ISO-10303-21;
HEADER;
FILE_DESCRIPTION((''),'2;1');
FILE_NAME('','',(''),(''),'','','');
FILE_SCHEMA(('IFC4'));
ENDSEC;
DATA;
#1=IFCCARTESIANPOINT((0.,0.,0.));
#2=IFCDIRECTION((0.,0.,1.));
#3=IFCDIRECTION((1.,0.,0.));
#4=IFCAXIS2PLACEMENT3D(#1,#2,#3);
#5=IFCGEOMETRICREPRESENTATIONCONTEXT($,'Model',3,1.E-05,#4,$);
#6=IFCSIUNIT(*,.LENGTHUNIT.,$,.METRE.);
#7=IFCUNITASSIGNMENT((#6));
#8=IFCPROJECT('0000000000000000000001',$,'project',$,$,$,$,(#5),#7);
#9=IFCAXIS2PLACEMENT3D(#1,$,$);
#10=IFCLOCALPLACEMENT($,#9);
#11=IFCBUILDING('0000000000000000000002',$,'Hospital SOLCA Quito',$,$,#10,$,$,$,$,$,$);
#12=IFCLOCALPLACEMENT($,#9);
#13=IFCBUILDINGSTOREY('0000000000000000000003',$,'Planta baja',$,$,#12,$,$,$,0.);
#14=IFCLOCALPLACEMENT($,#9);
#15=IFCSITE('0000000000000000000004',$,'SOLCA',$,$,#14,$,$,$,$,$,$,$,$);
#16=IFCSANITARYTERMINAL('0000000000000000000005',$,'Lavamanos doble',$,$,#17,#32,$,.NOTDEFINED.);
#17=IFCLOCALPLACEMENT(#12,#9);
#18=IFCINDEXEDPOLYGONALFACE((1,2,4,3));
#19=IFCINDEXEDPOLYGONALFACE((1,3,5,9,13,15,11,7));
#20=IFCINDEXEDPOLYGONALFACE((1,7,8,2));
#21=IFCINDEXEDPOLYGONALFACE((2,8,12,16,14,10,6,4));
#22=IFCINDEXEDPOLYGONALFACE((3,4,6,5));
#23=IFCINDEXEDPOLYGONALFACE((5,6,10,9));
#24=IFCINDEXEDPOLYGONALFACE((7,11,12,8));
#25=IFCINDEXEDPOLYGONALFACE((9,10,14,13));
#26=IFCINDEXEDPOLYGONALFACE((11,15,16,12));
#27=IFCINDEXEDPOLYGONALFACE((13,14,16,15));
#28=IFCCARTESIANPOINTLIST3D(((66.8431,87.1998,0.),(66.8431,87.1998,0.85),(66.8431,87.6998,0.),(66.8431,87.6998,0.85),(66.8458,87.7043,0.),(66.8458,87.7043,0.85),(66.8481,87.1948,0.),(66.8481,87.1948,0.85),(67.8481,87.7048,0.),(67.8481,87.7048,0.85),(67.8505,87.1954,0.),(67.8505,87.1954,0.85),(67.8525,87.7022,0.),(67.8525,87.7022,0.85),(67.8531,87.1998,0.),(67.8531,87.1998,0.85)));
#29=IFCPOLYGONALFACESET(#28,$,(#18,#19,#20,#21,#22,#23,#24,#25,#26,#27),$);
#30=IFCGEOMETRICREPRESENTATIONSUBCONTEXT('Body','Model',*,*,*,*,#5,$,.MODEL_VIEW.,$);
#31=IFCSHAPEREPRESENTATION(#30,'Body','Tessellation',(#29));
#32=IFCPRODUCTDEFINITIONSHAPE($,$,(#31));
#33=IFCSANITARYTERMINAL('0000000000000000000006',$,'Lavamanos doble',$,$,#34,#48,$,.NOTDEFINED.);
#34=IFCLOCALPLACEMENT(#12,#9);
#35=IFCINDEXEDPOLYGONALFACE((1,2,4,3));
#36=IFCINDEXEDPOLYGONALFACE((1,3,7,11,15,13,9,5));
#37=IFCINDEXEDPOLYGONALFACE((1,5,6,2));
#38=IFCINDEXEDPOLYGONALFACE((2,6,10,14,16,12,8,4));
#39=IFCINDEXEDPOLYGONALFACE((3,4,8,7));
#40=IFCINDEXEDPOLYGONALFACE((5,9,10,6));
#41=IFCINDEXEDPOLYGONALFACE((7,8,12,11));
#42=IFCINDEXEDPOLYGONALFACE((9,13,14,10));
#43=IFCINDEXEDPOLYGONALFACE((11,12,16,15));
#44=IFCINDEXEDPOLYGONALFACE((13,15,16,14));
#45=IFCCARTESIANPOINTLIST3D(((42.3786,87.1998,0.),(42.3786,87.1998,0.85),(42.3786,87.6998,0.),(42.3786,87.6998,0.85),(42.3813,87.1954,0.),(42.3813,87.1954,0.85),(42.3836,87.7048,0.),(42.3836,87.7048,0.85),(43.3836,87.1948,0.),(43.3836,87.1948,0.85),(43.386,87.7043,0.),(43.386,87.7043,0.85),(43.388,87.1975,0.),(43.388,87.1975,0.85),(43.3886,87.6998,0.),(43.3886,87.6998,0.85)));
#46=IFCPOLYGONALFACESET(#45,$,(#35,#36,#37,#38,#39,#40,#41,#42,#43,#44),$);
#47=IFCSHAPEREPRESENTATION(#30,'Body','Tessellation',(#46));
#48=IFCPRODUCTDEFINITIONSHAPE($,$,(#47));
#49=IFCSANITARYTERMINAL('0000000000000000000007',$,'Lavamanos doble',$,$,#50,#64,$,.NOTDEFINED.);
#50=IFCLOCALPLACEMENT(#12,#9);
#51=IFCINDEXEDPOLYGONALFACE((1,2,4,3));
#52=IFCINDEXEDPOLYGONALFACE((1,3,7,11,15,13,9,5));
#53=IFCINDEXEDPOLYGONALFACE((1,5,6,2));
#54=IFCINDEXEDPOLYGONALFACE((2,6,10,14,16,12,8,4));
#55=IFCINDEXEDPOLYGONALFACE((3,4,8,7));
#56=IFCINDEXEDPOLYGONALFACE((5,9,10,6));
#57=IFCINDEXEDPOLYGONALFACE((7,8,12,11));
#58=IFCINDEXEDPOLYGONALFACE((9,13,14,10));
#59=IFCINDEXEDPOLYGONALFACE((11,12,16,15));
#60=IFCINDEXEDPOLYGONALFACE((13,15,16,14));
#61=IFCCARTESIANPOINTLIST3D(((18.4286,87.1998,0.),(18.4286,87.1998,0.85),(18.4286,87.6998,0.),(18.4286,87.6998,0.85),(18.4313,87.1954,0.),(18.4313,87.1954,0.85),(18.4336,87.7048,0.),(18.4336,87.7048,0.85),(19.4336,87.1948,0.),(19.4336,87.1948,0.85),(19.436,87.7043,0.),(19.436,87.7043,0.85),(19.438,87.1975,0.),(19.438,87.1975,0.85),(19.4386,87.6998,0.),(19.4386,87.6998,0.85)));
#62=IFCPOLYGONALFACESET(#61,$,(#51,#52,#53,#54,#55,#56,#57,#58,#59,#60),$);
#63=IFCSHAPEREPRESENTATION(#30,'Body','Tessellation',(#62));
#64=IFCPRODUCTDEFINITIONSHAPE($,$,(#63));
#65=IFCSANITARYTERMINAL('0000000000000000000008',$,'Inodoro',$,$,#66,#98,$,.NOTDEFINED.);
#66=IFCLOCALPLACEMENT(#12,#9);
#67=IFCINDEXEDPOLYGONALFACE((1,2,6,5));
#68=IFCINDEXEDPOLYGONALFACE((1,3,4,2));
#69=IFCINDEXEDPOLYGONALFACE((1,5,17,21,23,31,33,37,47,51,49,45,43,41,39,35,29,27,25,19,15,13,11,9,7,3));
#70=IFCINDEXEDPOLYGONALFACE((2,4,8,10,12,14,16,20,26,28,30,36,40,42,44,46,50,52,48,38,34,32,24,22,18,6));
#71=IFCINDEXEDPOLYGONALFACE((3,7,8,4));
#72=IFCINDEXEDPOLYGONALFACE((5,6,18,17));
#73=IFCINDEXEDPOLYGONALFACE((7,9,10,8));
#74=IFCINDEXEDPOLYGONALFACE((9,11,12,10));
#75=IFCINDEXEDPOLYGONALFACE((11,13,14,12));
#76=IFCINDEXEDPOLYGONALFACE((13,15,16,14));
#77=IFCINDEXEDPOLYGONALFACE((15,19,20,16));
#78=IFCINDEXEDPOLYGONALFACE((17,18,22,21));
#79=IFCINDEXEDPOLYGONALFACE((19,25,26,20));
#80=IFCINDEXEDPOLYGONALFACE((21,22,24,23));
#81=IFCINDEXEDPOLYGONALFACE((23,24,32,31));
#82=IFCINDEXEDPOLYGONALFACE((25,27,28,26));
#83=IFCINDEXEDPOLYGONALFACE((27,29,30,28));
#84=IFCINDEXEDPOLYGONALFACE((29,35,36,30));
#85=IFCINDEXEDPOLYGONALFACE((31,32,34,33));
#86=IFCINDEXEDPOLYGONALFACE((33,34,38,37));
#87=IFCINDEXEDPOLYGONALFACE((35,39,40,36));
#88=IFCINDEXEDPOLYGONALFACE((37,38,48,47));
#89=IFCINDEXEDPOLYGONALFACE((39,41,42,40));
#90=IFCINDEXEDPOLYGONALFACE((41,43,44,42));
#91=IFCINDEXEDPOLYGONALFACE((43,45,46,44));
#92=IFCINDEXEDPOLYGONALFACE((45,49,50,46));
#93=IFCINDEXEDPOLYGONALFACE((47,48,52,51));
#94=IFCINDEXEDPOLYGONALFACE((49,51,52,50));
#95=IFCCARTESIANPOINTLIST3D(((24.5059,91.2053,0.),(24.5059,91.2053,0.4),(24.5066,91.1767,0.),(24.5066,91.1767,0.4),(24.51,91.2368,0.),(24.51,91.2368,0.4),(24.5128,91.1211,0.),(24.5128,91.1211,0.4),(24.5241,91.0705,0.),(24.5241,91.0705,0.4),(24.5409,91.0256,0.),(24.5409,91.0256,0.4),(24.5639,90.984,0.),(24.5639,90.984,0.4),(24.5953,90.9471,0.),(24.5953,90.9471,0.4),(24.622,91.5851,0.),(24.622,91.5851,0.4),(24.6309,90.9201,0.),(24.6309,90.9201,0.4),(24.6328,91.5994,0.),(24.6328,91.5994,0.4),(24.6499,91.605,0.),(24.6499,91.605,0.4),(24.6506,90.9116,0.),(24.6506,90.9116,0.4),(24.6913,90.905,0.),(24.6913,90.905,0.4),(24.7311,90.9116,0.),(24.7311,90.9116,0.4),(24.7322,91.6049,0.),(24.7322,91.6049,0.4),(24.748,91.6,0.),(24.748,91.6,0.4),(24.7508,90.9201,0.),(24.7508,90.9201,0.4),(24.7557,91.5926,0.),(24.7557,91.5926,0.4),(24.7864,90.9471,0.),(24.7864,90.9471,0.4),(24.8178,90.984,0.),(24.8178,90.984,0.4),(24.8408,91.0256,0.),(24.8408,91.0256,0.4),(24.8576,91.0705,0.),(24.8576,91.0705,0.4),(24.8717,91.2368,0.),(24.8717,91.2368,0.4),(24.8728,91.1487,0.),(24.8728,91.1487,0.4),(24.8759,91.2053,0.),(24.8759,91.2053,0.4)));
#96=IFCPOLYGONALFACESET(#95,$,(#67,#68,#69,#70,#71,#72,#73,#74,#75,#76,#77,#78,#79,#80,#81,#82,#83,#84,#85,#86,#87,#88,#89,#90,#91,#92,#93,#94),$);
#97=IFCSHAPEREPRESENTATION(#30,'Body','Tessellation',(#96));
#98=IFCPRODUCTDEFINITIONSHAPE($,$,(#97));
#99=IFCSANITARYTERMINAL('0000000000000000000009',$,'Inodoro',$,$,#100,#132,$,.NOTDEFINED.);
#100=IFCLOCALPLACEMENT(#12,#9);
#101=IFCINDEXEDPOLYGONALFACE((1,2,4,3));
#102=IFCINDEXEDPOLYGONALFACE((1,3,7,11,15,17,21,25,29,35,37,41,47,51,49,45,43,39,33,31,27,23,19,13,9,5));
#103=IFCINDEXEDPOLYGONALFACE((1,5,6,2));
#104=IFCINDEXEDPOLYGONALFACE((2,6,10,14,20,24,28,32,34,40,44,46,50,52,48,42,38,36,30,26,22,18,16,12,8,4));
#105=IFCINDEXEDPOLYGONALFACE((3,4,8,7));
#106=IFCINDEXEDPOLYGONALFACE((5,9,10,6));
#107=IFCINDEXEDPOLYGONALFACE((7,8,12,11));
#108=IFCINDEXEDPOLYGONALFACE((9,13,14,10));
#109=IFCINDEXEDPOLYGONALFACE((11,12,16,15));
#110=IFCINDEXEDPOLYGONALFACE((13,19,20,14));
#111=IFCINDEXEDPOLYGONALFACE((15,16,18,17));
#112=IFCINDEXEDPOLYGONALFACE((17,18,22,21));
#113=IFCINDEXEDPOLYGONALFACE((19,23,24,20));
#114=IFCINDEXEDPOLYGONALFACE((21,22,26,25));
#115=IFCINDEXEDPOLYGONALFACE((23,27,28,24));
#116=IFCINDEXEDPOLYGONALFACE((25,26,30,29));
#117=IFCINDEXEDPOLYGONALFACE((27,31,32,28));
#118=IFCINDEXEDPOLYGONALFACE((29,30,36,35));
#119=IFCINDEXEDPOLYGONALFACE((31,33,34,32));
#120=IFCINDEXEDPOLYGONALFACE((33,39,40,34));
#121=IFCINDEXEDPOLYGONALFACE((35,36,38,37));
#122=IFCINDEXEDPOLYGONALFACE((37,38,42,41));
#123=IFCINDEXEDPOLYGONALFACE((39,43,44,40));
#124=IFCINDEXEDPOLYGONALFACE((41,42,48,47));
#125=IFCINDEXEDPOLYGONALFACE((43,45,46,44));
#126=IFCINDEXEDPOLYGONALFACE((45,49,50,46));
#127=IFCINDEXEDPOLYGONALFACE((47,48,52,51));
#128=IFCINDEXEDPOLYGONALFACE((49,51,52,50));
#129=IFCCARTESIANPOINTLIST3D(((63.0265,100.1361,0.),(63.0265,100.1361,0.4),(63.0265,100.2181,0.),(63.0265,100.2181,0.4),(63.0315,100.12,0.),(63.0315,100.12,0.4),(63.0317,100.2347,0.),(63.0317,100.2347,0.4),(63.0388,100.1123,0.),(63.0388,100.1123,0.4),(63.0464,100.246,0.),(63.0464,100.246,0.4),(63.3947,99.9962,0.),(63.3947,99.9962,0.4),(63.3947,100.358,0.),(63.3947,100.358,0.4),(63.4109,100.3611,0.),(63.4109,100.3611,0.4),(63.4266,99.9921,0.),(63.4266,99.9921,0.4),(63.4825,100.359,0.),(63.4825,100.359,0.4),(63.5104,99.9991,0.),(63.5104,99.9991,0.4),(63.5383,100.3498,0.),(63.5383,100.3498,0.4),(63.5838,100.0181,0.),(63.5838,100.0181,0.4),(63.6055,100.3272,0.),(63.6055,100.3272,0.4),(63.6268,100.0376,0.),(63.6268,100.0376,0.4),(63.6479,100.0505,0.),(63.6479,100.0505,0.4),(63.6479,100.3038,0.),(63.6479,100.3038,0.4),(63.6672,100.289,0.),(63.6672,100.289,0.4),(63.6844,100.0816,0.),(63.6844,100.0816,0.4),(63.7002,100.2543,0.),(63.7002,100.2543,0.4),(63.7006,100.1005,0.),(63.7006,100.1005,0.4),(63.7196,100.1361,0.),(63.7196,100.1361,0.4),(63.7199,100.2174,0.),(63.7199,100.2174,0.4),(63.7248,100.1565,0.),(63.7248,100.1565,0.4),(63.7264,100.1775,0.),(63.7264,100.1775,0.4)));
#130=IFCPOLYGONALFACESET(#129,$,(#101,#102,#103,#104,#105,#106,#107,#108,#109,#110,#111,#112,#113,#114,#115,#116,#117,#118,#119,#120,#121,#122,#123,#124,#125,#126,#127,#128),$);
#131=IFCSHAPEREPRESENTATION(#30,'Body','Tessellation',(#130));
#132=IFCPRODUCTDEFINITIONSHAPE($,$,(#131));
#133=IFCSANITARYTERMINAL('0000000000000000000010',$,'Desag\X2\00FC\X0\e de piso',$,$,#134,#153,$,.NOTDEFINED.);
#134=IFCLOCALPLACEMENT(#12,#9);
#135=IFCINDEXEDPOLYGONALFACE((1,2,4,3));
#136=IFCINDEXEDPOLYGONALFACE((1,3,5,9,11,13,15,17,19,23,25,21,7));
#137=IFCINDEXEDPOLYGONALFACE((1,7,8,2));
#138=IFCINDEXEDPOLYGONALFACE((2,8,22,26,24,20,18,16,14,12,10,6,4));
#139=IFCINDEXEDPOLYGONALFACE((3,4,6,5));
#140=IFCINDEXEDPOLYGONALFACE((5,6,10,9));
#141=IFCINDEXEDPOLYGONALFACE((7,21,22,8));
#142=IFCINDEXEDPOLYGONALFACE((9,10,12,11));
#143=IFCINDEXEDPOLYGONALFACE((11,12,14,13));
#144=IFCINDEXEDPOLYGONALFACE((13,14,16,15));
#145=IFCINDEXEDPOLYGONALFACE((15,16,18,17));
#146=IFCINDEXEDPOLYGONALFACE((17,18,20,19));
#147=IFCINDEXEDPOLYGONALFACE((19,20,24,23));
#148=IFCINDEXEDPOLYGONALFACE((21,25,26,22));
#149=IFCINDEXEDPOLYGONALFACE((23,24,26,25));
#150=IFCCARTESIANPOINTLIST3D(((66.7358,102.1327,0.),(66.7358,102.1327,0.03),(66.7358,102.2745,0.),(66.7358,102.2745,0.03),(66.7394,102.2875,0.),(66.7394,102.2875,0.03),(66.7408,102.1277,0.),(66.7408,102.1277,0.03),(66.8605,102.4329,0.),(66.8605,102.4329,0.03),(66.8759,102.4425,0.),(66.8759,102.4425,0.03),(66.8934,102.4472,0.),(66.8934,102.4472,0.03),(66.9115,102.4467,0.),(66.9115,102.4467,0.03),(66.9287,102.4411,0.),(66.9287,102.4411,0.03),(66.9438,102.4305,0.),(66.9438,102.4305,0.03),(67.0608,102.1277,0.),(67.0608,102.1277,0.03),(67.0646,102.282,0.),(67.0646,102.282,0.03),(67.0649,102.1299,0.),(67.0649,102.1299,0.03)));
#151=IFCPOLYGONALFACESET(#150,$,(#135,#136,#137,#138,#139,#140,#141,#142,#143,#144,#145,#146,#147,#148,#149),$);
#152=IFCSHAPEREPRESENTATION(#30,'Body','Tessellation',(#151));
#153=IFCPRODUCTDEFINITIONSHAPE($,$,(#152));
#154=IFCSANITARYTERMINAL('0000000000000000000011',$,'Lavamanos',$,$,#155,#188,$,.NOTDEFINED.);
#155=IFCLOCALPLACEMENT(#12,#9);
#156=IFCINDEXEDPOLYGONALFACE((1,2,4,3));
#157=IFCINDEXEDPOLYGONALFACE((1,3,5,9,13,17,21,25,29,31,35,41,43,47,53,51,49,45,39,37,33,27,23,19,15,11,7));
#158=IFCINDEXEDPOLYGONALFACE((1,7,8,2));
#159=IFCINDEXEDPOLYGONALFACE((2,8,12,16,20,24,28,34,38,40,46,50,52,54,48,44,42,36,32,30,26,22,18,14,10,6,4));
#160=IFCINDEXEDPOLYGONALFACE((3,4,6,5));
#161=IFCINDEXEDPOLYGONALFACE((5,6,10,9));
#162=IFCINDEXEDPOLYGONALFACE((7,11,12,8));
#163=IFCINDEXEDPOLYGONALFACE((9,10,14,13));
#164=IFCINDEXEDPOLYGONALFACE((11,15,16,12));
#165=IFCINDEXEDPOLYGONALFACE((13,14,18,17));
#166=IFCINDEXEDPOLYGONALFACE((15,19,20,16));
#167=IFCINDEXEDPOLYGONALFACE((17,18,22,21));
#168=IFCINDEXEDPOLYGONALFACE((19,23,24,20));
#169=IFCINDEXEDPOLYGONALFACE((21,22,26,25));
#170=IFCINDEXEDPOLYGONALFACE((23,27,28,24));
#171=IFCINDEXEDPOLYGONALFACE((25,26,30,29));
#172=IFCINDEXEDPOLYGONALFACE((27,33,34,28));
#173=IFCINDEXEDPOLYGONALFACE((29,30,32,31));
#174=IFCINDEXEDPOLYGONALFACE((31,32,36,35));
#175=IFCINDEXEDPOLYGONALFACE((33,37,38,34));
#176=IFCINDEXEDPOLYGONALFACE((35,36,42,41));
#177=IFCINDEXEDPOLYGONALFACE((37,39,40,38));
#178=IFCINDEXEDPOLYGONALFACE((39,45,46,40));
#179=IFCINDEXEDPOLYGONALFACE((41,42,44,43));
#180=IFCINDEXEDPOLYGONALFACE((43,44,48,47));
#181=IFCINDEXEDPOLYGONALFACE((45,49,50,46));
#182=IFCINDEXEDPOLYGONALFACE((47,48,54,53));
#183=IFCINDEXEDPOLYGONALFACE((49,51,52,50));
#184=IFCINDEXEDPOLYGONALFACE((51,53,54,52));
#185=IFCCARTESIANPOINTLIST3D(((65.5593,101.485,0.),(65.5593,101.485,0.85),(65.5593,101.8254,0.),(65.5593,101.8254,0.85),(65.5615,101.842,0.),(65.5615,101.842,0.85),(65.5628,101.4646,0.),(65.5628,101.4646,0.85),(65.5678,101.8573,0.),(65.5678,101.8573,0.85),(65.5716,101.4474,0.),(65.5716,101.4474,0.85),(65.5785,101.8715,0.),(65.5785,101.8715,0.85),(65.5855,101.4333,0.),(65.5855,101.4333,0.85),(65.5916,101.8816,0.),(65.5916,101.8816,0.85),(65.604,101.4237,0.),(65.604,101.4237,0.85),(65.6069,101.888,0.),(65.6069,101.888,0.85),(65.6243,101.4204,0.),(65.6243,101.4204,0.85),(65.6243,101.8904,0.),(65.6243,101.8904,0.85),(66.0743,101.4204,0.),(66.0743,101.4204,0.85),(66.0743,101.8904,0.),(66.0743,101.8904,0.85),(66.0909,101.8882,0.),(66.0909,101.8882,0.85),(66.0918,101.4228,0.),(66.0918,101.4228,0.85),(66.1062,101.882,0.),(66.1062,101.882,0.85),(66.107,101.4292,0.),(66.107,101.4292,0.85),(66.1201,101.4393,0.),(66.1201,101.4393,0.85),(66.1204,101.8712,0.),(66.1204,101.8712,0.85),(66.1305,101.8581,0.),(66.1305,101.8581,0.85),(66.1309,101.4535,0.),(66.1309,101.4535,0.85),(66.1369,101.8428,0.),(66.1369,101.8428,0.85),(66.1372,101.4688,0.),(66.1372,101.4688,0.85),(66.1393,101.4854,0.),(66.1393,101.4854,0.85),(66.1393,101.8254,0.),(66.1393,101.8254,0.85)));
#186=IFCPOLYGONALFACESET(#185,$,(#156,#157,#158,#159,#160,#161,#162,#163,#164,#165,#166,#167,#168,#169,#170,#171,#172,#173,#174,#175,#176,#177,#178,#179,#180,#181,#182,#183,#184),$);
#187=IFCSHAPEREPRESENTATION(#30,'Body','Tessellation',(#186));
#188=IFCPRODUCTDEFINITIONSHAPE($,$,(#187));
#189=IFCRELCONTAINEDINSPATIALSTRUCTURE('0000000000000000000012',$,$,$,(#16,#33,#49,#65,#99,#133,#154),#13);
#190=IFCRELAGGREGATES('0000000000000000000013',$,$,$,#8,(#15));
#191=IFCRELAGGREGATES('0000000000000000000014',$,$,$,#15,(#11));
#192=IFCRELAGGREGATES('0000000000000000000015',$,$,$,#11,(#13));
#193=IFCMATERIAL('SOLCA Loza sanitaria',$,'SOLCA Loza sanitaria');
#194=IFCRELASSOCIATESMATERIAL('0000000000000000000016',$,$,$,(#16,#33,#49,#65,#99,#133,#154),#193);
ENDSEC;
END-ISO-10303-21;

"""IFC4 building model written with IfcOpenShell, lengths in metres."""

from ifc_helpers import new_model, si_unit, origin, origin_with_axes, place, context, subcontext, project, spatial, polyline, outline, extrude, material, element, save


model = new_model("IFC4")

# Units and contexts
model_context = context("Model", 3, precision=1e-05, world=origin_with_axes())
body_context = subcontext(model_context, "Body", "Model", "MODEL_VIEW")
ifc_project = project(units=[si_unit("LENGTHUNIT", "METRE")], contexts=[model_context])

# Site, building, storey
site_placement = place(None, origin())
site = spatial("IfcSite", under=ifc_project, at=site_placement, Name="SOLCA")
building_placement = place(None, origin())
building = spatial("IfcBuilding", under=site, at=building_placement, Name="Hospital SOLCA Quito")
storey_placement = place(None, origin())
storey = spatial("IfcBuildingStorey", under=building, at=storey_placement, Name="Planta baja", Elevation=0.0)

# Sanitary terminals
ifc_material = material(Name="SOLCA Loza sanitaria", Category="SOLCA Loza sanitaria")
sanitary_terminal_1_placement = place(storey_placement, origin_with_axes())
element("IfcSanitaryTerminal", 1, at=sanitary_terminal_1_placement, inside=storey, material=ifc_material, Name="Lavamanos doble", PredefinedType="NOTDEFINED", context=body_context, shape_type="SweptSolid", body=[
    extrude(outline(polyline([(66.8481, 87.1948), (66.8431, 87.1998), (66.8431, 87.6998), (66.8458, 87.7043), (67.8481, 87.7048), (67.8525, 87.7022), (67.8531, 87.1998), (67.8505, 87.1954), (66.8481, 87.1948)])), origin_with_axes(), (0.0, 0.0, 1.0), 0.85),
])
sanitary_terminal_2_placement = place(storey_placement, origin_with_axes())
element("IfcSanitaryTerminal", 2, at=sanitary_terminal_2_placement, inside=storey, material=ifc_material, Name="Lavamanos doble", PredefinedType="NOTDEFINED", context=body_context, shape_type="SweptSolid", body=[
    extrude(outline(polyline([(42.3786, 87.6998), (42.3836, 87.7048), (43.386, 87.7043), (43.3886, 87.6998), (43.388, 87.1975), (43.3836, 87.1948), (42.3813, 87.1954), (42.3786, 87.1998), (42.3786, 87.6998)])), origin_with_axes(), (0.0, 0.0, 1.0), 0.85),
])
sanitary_terminal_3_placement = place(storey_placement, origin_with_axes())
element("IfcSanitaryTerminal", 3, at=sanitary_terminal_3_placement, inside=storey, material=ifc_material, Name="Lavamanos doble", PredefinedType="NOTDEFINED", context=body_context, shape_type="SweptSolid", body=[
    extrude(outline(polyline([(18.4286, 87.6998), (18.4336, 87.7048), (19.436, 87.7043), (19.4386, 87.6998), (19.438, 87.1975), (19.4336, 87.1948), (18.4313, 87.1954), (18.4286, 87.1998), (18.4286, 87.6998)])), origin_with_axes(), (0.0, 0.0, 1.0), 0.85),
])
sanitary_terminal_4_placement = place(storey_placement, origin_with_axes())
element("IfcSanitaryTerminal", 4, at=sanitary_terminal_4_placement, inside=storey, material=ifc_material, Name="Inodoro", PredefinedType="NOTDEFINED", context=body_context, shape_type="SweptSolid", body=[
    extrude(outline(polyline([(24.6913, 90.905), (24.6506, 90.9116), (24.6309, 90.9201), (24.5953, 90.9471), (24.5639, 90.984), (24.5409, 91.0256), (24.5241, 91.0705), (24.5128, 91.1211), (24.5066, 91.1767), (24.5059, 91.2053), (24.51, 91.2368), (24.622, 91.5851), (24.6328, 91.5994), (24.6499, 91.605), (24.7322, 91.6049), (24.748, 91.6), (24.7557, 91.5926), (24.8717, 91.2368), (24.8759, 91.2053), (24.8728, 91.1487), (24.8576, 91.0705), (24.8408, 91.0256), (24.8178, 90.984), (24.7864, 90.9471), (24.7508, 90.9201), (24.7311, 90.9116), (24.6913, 90.905)])), origin_with_axes(), (0.0, 0.0, 1.0), 0.4),
])
sanitary_terminal_5_placement = place(storey_placement, origin_with_axes())
element("IfcSanitaryTerminal", 5, at=sanitary_terminal_5_placement, inside=storey, material=ifc_material, Name="Inodoro", PredefinedType="NOTDEFINED", context=body_context, shape_type="SweptSolid", body=[
    extrude(outline(polyline([(63.4266, 99.9921), (63.3947, 99.9962), (63.0388, 100.1123), (63.0315, 100.12), (63.0265, 100.1361), (63.0265, 100.2181), (63.0317, 100.2347), (63.0464, 100.246), (63.3947, 100.358), (63.4109, 100.3611), (63.4825, 100.359), (63.5383, 100.3498), (63.6055, 100.3272), (63.6479, 100.3038), (63.6672, 100.289), (63.7002, 100.2543), (63.7199, 100.2174), (63.7264, 100.1775), (63.7248, 100.1565), (63.7196, 100.1361), (63.7006, 100.1005), (63.6844, 100.0816), (63.6479, 100.0505), (63.6268, 100.0376), (63.5838, 100.0181), (63.5104, 99.9991), (63.4266, 99.9921)])), origin_with_axes(), (0.0, 0.0, 1.0), 0.4),
])
sanitary_terminal_6_placement = place(storey_placement, origin_with_axes())
element("IfcSanitaryTerminal", 6, at=sanitary_terminal_6_placement, inside=storey, material=ifc_material, Name="Desagüe de piso", PredefinedType="NOTDEFINED", context=body_context, shape_type="SweptSolid", body=[
    extrude(outline(polyline([(66.7408, 102.1277), (66.7358, 102.1327), (66.7358, 102.2745), (66.7394, 102.2875), (66.8605, 102.4329), (66.8759, 102.4425), (66.8934, 102.4472), (66.9115, 102.4467), (66.9287, 102.4411), (66.9438, 102.4305), (67.0646, 102.282), (67.0649, 102.1299), (67.0608, 102.1277), (66.7408, 102.1277)])), origin_with_axes(), (0.0, 0.0, 1.0), 0.03),
])
sanitary_terminal_7_placement = place(storey_placement, origin_with_axes())
element("IfcSanitaryTerminal", 7, at=sanitary_terminal_7_placement, inside=storey, material=ifc_material, Name="Lavamanos", PredefinedType="NOTDEFINED", context=body_context, shape_type="SweptSolid", body=[
    extrude(outline(polyline([(65.6243, 101.4204), (65.604, 101.4237), (65.5855, 101.4333), (65.5716, 101.4474), (65.5628, 101.4646), (65.5593, 101.485), (65.5593, 101.8254), (65.5615, 101.842), (65.5678, 101.8573), (65.5785, 101.8715), (65.5916, 101.8816), (65.6069, 101.888), (65.6243, 101.8904), (66.0743, 101.8904), (66.0909, 101.8882), (66.1062, 101.882), (66.1204, 101.8712), (66.1305, 101.8581), (66.1369, 101.8428), (66.1393, 101.8254), (66.1393, 101.4854), (66.1372, 101.4688), (66.1309, 101.4535), (66.1201, 101.4393), (66.107, 101.4292), (66.0918, 101.4228), (66.0743, 101.4204), (65.6243, 101.4204)])), origin_with_axes(), (0.0, 0.0, 1.0), 0.85),
])

save(model, "model.ifc")
